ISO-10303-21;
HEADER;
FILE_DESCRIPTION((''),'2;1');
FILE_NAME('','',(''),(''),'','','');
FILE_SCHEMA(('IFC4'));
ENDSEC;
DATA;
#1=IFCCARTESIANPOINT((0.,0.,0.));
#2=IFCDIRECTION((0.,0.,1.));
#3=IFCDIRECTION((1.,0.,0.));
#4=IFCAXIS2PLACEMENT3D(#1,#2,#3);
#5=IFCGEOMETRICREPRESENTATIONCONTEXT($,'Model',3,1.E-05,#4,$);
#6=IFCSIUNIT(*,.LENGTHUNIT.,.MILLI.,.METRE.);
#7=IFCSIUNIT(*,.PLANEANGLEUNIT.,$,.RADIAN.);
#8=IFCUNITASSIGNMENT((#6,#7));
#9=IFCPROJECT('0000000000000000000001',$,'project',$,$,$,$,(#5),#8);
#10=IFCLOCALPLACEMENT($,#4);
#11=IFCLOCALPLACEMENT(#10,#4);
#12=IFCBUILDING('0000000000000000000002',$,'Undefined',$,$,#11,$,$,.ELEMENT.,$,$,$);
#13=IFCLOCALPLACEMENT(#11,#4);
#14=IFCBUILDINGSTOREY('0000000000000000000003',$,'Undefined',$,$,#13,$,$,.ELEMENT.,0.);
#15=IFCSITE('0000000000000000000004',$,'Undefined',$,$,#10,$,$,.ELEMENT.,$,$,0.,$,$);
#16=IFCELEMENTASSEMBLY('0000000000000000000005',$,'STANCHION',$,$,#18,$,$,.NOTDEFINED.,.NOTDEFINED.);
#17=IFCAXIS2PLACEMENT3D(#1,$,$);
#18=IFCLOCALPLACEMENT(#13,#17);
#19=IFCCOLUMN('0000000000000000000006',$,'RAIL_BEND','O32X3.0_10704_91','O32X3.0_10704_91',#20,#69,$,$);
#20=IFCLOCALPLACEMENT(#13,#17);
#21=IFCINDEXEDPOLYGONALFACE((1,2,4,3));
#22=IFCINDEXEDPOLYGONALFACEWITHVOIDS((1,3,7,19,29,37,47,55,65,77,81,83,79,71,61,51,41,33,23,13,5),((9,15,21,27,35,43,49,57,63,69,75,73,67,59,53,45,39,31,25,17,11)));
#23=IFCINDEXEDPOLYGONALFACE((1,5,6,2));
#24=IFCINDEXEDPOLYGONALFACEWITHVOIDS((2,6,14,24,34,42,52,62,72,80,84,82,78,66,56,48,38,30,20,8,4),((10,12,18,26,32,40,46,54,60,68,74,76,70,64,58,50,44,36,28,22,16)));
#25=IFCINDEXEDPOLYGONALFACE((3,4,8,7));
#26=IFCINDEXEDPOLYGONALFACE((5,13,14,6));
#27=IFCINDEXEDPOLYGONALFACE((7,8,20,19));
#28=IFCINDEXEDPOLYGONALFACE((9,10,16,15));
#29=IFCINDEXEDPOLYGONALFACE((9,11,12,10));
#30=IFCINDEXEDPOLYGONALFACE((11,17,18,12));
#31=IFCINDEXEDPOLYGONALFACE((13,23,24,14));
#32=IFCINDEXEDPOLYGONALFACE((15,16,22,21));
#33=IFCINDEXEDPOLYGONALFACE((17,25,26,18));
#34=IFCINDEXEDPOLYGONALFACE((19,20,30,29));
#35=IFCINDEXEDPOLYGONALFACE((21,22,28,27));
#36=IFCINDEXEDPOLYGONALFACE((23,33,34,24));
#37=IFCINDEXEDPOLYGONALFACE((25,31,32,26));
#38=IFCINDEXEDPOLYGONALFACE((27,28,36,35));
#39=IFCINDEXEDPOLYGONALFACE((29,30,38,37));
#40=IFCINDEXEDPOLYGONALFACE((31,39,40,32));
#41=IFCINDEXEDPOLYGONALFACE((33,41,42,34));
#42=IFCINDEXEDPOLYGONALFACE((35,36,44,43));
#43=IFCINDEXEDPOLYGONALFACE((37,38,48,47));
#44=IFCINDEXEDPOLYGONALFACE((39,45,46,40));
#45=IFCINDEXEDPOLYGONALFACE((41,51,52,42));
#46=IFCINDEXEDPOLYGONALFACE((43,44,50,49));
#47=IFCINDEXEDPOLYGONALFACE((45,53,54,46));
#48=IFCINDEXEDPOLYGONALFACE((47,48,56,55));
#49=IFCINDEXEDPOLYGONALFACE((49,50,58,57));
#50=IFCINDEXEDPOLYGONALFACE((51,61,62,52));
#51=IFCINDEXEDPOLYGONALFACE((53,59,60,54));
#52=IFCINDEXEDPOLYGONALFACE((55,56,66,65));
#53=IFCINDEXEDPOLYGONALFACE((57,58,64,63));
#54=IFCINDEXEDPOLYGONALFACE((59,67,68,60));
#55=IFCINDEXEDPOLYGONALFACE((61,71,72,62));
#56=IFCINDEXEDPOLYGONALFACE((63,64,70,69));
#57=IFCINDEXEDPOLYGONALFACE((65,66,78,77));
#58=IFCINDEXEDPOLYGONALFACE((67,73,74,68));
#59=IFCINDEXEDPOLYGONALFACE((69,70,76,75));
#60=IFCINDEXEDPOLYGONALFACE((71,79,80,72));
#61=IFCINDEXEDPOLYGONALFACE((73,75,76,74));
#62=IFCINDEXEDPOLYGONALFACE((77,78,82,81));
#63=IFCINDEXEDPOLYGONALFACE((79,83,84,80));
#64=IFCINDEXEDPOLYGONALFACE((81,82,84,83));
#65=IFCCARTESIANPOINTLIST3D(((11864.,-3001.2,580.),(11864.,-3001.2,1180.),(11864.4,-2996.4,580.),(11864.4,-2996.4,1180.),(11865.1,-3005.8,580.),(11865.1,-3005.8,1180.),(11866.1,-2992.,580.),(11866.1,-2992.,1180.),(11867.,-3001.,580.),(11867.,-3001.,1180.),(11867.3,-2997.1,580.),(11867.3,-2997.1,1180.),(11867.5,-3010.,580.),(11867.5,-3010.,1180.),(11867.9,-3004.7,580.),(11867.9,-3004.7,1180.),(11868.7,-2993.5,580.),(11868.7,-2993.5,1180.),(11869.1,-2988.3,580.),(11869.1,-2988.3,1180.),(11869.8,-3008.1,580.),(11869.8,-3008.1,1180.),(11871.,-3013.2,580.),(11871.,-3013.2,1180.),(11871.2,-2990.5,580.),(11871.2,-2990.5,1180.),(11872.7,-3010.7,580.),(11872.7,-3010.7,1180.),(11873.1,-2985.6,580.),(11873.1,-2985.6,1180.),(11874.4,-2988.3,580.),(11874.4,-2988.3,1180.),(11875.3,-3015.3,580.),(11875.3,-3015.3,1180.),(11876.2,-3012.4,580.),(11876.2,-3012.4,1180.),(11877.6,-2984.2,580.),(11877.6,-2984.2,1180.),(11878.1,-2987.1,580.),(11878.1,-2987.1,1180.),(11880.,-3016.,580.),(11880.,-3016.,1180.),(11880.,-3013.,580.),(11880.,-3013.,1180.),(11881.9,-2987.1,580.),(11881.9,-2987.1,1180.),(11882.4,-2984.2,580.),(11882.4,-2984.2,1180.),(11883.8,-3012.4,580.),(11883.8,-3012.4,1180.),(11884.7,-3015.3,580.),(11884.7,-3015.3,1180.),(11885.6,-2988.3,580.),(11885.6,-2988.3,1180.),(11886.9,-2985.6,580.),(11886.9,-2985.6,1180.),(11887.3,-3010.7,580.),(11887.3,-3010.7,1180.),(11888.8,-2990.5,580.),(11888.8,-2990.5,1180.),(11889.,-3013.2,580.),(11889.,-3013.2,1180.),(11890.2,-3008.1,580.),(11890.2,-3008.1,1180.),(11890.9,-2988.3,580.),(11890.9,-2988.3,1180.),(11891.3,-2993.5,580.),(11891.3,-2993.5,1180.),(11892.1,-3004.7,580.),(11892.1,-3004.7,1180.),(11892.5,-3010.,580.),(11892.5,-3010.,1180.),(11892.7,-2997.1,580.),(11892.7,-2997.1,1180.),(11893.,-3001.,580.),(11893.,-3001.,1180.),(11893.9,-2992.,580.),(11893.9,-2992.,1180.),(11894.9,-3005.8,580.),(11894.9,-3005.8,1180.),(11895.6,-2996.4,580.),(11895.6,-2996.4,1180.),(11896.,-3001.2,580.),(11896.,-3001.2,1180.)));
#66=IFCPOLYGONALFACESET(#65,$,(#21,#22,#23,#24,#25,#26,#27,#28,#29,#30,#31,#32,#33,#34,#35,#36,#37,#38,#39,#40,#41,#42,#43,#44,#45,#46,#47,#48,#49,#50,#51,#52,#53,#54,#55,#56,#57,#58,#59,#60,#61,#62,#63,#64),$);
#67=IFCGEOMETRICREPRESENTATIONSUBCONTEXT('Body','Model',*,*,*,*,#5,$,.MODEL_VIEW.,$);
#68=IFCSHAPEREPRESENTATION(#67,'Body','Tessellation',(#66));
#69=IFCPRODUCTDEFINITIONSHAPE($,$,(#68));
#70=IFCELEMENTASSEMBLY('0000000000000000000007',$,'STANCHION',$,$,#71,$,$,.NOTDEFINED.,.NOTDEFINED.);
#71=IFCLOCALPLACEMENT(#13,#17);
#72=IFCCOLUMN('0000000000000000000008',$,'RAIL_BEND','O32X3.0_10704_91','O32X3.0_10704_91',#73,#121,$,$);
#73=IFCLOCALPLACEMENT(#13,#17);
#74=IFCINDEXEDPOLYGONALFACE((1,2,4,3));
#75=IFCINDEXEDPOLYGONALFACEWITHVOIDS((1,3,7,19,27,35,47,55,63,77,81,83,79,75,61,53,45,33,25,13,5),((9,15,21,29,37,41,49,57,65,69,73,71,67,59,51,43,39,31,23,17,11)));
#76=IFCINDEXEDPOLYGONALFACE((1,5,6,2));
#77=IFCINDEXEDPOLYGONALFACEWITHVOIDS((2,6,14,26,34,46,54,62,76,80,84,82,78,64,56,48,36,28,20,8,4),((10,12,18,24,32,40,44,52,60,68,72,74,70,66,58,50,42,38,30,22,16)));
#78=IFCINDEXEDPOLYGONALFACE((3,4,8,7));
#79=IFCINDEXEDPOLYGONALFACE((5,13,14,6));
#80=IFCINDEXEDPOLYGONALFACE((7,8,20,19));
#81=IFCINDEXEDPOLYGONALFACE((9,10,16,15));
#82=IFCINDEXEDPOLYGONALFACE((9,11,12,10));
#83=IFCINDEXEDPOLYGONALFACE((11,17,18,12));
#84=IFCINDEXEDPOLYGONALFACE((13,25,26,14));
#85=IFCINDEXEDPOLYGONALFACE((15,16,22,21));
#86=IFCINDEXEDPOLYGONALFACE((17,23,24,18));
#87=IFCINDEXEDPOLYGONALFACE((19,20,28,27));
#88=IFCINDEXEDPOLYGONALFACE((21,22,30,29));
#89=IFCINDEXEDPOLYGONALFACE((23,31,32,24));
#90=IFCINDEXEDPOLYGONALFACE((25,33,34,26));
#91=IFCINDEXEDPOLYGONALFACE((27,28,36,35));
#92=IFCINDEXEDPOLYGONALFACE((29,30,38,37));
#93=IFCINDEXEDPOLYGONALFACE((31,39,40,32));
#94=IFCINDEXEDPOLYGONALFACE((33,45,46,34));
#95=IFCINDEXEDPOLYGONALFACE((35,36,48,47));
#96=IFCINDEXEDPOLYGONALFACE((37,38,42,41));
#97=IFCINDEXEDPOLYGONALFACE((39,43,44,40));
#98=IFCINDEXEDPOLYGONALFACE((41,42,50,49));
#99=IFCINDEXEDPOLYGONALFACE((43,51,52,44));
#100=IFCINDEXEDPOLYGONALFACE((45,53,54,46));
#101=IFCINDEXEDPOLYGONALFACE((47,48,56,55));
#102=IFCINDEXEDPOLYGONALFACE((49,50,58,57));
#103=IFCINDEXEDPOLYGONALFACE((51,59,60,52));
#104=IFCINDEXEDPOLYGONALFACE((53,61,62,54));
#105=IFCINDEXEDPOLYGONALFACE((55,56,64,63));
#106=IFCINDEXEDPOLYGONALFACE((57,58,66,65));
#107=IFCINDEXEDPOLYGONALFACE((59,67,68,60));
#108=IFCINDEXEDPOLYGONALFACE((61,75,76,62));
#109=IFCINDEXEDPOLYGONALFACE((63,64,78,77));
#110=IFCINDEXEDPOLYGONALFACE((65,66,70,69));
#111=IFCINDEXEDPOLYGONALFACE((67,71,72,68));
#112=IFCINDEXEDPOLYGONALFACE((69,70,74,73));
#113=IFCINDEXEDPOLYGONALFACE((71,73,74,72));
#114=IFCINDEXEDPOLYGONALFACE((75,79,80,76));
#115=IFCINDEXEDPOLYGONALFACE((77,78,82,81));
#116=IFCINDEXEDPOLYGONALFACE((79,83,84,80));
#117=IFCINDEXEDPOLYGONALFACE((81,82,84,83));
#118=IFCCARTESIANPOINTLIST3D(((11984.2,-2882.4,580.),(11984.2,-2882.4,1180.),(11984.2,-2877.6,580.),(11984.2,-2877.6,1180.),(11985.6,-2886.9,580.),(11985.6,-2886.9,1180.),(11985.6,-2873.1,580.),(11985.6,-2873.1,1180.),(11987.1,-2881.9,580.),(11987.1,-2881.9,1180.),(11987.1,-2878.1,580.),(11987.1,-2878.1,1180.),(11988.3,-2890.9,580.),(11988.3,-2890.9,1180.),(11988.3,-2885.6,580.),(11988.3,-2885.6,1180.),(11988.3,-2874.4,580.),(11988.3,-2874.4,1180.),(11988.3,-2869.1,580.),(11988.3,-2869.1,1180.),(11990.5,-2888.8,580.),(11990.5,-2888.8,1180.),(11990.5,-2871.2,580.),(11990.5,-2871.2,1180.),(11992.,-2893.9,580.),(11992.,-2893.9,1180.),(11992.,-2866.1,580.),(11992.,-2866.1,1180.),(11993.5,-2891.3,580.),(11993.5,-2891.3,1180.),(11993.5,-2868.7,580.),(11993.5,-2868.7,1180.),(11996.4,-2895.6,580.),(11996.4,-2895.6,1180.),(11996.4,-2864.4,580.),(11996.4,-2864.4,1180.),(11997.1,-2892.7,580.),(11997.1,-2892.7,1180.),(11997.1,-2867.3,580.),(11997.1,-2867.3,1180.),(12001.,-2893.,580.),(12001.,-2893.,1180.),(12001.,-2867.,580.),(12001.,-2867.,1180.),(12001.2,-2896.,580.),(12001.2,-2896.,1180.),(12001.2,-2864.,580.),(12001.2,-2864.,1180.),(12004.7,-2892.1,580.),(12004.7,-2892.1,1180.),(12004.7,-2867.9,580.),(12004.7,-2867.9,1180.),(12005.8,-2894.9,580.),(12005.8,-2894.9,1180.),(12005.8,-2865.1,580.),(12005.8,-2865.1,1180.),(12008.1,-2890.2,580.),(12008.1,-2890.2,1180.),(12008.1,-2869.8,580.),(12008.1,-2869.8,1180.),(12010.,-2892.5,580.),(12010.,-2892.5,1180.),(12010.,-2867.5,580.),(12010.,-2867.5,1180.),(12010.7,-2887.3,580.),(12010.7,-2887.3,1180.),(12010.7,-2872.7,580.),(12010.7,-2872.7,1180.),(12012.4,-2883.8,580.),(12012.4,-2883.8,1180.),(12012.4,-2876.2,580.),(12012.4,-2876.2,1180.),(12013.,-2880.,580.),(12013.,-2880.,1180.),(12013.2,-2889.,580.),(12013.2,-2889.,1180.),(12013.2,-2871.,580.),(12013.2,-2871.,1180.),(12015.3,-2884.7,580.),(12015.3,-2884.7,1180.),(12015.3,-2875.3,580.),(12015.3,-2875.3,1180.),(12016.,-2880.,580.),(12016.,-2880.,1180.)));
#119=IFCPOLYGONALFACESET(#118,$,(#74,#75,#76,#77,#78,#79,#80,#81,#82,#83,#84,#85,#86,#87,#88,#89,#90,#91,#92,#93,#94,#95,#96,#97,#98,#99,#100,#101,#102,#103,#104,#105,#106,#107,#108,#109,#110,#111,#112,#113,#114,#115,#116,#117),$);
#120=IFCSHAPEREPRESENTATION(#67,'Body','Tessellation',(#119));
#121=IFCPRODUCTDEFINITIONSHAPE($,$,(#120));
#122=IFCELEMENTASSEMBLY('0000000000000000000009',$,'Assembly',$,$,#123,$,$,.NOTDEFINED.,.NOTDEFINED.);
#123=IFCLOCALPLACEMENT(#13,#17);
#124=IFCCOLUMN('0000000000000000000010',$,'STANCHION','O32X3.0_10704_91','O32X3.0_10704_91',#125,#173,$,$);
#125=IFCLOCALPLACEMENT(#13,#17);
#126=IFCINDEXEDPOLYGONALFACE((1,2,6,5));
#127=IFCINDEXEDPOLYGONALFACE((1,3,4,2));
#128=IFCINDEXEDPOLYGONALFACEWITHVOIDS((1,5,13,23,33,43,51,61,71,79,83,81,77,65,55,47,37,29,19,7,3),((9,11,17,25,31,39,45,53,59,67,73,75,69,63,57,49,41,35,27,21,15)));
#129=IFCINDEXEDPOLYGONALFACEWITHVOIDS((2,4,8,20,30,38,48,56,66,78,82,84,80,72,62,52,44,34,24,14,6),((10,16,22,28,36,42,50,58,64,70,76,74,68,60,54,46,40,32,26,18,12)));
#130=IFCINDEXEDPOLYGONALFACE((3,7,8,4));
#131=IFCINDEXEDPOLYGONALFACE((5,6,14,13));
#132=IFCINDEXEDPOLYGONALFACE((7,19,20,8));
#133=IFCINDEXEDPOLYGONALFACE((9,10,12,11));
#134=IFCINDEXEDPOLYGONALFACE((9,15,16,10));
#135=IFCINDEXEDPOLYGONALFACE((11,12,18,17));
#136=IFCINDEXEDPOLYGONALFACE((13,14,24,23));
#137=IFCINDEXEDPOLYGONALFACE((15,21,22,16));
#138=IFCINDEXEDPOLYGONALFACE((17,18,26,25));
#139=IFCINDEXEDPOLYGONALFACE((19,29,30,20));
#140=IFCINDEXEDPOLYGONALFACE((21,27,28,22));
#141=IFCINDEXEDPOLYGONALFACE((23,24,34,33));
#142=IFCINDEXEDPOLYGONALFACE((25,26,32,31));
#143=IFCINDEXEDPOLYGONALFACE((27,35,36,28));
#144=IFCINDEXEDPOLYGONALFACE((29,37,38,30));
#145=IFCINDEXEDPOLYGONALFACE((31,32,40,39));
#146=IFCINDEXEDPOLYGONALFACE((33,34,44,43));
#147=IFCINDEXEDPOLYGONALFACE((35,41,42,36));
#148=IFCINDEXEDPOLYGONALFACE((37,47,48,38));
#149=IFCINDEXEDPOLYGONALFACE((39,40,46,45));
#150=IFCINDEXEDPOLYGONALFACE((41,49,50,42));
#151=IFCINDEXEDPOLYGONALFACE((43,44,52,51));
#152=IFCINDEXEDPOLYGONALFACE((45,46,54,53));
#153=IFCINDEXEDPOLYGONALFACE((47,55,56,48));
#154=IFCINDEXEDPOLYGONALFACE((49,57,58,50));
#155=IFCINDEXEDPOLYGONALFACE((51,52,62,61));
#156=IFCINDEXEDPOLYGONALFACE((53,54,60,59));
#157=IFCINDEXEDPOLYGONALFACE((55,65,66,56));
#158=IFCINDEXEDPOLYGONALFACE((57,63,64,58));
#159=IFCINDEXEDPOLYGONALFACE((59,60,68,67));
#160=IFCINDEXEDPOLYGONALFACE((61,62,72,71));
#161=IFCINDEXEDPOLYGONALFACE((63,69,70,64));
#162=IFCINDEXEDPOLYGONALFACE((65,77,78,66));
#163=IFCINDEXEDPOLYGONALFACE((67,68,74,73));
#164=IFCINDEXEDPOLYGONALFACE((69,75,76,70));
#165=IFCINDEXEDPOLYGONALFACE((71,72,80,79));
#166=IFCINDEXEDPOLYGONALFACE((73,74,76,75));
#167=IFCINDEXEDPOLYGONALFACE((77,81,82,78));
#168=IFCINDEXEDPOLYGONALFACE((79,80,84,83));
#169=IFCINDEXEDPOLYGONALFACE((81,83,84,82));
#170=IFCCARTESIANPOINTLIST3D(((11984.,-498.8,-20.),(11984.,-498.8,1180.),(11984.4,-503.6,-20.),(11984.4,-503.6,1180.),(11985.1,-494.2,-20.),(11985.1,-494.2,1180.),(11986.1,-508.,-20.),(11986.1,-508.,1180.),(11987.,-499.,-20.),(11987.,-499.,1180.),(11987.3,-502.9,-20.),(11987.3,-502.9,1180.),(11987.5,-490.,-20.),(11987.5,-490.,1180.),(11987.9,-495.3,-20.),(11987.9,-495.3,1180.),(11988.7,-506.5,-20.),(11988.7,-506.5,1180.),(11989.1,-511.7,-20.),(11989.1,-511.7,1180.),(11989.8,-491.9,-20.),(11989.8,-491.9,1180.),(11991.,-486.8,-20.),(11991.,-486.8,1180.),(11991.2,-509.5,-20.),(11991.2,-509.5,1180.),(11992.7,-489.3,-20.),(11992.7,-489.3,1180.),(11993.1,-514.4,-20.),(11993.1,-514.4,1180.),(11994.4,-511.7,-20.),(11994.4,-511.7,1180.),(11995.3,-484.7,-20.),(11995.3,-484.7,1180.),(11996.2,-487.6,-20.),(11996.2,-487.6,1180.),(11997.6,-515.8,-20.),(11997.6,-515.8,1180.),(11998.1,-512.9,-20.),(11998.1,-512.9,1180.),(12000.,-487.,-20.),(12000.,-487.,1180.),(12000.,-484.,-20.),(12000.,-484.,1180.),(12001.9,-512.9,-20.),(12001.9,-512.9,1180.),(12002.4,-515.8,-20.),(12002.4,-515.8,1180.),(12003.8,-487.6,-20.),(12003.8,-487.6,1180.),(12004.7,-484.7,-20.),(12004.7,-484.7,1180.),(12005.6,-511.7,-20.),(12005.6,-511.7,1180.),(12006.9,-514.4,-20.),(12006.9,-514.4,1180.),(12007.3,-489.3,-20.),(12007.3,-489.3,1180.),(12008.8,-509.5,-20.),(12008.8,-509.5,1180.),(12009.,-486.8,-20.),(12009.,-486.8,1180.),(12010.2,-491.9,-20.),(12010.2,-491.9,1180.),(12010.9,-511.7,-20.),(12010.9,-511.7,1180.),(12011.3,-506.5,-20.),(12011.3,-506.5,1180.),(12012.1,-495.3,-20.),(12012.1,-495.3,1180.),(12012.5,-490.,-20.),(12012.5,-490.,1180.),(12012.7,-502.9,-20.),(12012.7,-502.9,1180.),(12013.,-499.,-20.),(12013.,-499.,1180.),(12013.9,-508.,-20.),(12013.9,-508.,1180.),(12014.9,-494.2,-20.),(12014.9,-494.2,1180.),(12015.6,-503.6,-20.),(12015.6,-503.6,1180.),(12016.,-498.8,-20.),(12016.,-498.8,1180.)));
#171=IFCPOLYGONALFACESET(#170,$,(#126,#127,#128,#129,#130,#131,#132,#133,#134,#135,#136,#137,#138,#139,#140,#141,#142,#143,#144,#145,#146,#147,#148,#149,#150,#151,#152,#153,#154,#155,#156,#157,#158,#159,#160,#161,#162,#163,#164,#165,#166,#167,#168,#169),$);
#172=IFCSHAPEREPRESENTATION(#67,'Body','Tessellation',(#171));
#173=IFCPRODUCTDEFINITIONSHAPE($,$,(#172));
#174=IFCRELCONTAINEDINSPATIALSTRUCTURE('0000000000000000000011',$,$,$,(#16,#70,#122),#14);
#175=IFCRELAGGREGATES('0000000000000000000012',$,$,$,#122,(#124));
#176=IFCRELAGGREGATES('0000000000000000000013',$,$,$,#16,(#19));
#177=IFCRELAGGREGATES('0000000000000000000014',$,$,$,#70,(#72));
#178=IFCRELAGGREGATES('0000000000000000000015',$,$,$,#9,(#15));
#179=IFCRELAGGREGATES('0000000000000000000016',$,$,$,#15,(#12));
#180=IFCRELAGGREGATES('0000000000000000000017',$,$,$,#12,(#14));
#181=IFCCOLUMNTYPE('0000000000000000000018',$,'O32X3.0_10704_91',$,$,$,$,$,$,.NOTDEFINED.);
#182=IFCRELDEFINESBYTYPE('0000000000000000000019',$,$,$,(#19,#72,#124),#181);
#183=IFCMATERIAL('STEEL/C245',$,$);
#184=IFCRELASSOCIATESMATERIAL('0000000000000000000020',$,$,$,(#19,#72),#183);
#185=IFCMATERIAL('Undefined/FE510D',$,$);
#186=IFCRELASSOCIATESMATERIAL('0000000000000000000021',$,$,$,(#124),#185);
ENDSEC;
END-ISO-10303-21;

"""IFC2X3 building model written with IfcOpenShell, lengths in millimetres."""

from ifc_helpers import new_model, si_unit, frame, origin_with_axes, origin_2d_with_axis, place, context, subcontext, project, spatial, hollow_circle, extrude, material, type_object, element, aggregate, save


model = new_model("IFC2X3")

# Units and contexts
model_context = context("Model", 3, precision=1e-05, world=origin_with_axes())
body_context = subcontext(model_context, "Body", "Model", "MODEL_VIEW")
ifc_project = project(units=[si_unit("LENGTHUNIT", "METRE", prefix="MILLI"), si_unit("PLANEANGLEUNIT", "RADIAN")], contexts=[model_context])

# Site, building, storey
site_placement = place(None, origin_with_axes())
site = spatial("IfcSite", under=ifc_project, at=site_placement, Name="Undefined", CompositionType="ELEMENT", RefElevation=0.0)
building_placement = place(site_placement, origin_with_axes())
building = spatial("IfcBuilding", under=site, at=building_placement, Name="Undefined", CompositionType="ELEMENT")
storey_placement = place(building_placement, origin_with_axes())
storey = spatial("IfcBuildingStorey", under=building, at=storey_placement, Name="Undefined", CompositionType="ELEMENT", Elevation=0.0)

# Element assemblies, columns
assembly_1_placement = place(storey_placement, origin_with_axes())
assembly_1 = element("IfcElementAssembly", 1, at=assembly_1_placement, inside=storey, Name="STANCHION", AssemblyPlace="NOTDEFINED", PredefinedType="NOTDEFINED")
ifc_material_1 = material(Name="STEEL/C245")
column_type = type_object("IfcColumnType", Name="O32X3.0_10704_91", PredefinedType="NOTDEFINED")
column_1_placement = place(assembly_1_placement, frame((11880.0, -3000.0, 580.0), z_axis=(0.0, 0.0, 1.0), x_axis=(-1.0, 0.0, 0.0)))
column_1 = element("IfcColumn", 2, at=column_1_placement, type_object=column_type, material=ifc_material_1, Name="RAIL_BEND", Description="O32X3.0_10704_91", ObjectType="O32X3.0_10704_91", context=body_context, shape_type="SweptSolid", body=[
    extrude(hollow_circle(Radius=16.0, WallThickness=3.0, at=origin_2d_with_axis()), frame((0.0, 0.0, 600.0), z_axis=(0.0, 0.0, -1.0), x_axis=(0.0, 1.0, 0.0)), (0.0, 0.0, 1.0), 600.0),
])
assembly_2_placement = place(storey_placement, origin_with_axes())
assembly_2 = element("IfcElementAssembly", 3, at=assembly_2_placement, inside=storey, Name="STANCHION", AssemblyPlace="NOTDEFINED", PredefinedType="NOTDEFINED")
column_2_placement = place(assembly_2_placement, frame((12000.0, -2880.0, 580.0), z_axis=(0.0, 0.0, 1.0), x_axis=(0.0, -1.0, 0.0)))
column_2 = element("IfcColumn", 4, at=column_2_placement, type_object=column_type, material=ifc_material_1, Name="RAIL_BEND", Description="O32X3.0_10704_91", ObjectType="O32X3.0_10704_91", context=body_context, shape_type="SweptSolid", body=[
    extrude(hollow_circle(Radius=16.0, WallThickness=3.0, at=origin_2d_with_axis()), frame((0.0, 0.0, 600.0), z_axis=(0.0, 0.0, -1.0), x_axis=(0.0, 1.0, 0.0)), (0.0, 0.0, 1.0), 600.0),
])
assembly_3_placement = place(storey_placement, origin_with_axes())
assembly_3 = element("IfcElementAssembly", 5, at=assembly_3_placement, inside=storey, Name="Assembly", AssemblyPlace="NOTDEFINED", PredefinedType="NOTDEFINED")
ifc_material_2 = material(Name="Undefined/FE510D")
column_3_placement = place(assembly_3_placement, frame((12000.0, -500.0, -20.0), z_axis=(0.0, 0.0, 1.0), x_axis=(1.0, 0.0, 0.0)))
column_3 = element("IfcColumn", 6, at=column_3_placement, type_object=column_type, material=ifc_material_2, Name="STANCHION", Description="O32X3.0_10704_91", ObjectType="O32X3.0_10704_91", context=body_context, shape_type="SweptSolid", body=[
    extrude(hollow_circle(Radius=16.0, WallThickness=3.0, at=origin_2d_with_axis()), frame((0.0, 0.0, 1200.0), z_axis=(0.0, 0.0, -1.0), x_axis=(0.0, 1.0, 0.0)), (0.0, 0.0, 1.0), 1200.0),
])
aggregate(assembly_3, [column_3])

aggregate(assembly_1, [column_1])
aggregate(assembly_2, [column_2])

save(model, "model.ifc")
